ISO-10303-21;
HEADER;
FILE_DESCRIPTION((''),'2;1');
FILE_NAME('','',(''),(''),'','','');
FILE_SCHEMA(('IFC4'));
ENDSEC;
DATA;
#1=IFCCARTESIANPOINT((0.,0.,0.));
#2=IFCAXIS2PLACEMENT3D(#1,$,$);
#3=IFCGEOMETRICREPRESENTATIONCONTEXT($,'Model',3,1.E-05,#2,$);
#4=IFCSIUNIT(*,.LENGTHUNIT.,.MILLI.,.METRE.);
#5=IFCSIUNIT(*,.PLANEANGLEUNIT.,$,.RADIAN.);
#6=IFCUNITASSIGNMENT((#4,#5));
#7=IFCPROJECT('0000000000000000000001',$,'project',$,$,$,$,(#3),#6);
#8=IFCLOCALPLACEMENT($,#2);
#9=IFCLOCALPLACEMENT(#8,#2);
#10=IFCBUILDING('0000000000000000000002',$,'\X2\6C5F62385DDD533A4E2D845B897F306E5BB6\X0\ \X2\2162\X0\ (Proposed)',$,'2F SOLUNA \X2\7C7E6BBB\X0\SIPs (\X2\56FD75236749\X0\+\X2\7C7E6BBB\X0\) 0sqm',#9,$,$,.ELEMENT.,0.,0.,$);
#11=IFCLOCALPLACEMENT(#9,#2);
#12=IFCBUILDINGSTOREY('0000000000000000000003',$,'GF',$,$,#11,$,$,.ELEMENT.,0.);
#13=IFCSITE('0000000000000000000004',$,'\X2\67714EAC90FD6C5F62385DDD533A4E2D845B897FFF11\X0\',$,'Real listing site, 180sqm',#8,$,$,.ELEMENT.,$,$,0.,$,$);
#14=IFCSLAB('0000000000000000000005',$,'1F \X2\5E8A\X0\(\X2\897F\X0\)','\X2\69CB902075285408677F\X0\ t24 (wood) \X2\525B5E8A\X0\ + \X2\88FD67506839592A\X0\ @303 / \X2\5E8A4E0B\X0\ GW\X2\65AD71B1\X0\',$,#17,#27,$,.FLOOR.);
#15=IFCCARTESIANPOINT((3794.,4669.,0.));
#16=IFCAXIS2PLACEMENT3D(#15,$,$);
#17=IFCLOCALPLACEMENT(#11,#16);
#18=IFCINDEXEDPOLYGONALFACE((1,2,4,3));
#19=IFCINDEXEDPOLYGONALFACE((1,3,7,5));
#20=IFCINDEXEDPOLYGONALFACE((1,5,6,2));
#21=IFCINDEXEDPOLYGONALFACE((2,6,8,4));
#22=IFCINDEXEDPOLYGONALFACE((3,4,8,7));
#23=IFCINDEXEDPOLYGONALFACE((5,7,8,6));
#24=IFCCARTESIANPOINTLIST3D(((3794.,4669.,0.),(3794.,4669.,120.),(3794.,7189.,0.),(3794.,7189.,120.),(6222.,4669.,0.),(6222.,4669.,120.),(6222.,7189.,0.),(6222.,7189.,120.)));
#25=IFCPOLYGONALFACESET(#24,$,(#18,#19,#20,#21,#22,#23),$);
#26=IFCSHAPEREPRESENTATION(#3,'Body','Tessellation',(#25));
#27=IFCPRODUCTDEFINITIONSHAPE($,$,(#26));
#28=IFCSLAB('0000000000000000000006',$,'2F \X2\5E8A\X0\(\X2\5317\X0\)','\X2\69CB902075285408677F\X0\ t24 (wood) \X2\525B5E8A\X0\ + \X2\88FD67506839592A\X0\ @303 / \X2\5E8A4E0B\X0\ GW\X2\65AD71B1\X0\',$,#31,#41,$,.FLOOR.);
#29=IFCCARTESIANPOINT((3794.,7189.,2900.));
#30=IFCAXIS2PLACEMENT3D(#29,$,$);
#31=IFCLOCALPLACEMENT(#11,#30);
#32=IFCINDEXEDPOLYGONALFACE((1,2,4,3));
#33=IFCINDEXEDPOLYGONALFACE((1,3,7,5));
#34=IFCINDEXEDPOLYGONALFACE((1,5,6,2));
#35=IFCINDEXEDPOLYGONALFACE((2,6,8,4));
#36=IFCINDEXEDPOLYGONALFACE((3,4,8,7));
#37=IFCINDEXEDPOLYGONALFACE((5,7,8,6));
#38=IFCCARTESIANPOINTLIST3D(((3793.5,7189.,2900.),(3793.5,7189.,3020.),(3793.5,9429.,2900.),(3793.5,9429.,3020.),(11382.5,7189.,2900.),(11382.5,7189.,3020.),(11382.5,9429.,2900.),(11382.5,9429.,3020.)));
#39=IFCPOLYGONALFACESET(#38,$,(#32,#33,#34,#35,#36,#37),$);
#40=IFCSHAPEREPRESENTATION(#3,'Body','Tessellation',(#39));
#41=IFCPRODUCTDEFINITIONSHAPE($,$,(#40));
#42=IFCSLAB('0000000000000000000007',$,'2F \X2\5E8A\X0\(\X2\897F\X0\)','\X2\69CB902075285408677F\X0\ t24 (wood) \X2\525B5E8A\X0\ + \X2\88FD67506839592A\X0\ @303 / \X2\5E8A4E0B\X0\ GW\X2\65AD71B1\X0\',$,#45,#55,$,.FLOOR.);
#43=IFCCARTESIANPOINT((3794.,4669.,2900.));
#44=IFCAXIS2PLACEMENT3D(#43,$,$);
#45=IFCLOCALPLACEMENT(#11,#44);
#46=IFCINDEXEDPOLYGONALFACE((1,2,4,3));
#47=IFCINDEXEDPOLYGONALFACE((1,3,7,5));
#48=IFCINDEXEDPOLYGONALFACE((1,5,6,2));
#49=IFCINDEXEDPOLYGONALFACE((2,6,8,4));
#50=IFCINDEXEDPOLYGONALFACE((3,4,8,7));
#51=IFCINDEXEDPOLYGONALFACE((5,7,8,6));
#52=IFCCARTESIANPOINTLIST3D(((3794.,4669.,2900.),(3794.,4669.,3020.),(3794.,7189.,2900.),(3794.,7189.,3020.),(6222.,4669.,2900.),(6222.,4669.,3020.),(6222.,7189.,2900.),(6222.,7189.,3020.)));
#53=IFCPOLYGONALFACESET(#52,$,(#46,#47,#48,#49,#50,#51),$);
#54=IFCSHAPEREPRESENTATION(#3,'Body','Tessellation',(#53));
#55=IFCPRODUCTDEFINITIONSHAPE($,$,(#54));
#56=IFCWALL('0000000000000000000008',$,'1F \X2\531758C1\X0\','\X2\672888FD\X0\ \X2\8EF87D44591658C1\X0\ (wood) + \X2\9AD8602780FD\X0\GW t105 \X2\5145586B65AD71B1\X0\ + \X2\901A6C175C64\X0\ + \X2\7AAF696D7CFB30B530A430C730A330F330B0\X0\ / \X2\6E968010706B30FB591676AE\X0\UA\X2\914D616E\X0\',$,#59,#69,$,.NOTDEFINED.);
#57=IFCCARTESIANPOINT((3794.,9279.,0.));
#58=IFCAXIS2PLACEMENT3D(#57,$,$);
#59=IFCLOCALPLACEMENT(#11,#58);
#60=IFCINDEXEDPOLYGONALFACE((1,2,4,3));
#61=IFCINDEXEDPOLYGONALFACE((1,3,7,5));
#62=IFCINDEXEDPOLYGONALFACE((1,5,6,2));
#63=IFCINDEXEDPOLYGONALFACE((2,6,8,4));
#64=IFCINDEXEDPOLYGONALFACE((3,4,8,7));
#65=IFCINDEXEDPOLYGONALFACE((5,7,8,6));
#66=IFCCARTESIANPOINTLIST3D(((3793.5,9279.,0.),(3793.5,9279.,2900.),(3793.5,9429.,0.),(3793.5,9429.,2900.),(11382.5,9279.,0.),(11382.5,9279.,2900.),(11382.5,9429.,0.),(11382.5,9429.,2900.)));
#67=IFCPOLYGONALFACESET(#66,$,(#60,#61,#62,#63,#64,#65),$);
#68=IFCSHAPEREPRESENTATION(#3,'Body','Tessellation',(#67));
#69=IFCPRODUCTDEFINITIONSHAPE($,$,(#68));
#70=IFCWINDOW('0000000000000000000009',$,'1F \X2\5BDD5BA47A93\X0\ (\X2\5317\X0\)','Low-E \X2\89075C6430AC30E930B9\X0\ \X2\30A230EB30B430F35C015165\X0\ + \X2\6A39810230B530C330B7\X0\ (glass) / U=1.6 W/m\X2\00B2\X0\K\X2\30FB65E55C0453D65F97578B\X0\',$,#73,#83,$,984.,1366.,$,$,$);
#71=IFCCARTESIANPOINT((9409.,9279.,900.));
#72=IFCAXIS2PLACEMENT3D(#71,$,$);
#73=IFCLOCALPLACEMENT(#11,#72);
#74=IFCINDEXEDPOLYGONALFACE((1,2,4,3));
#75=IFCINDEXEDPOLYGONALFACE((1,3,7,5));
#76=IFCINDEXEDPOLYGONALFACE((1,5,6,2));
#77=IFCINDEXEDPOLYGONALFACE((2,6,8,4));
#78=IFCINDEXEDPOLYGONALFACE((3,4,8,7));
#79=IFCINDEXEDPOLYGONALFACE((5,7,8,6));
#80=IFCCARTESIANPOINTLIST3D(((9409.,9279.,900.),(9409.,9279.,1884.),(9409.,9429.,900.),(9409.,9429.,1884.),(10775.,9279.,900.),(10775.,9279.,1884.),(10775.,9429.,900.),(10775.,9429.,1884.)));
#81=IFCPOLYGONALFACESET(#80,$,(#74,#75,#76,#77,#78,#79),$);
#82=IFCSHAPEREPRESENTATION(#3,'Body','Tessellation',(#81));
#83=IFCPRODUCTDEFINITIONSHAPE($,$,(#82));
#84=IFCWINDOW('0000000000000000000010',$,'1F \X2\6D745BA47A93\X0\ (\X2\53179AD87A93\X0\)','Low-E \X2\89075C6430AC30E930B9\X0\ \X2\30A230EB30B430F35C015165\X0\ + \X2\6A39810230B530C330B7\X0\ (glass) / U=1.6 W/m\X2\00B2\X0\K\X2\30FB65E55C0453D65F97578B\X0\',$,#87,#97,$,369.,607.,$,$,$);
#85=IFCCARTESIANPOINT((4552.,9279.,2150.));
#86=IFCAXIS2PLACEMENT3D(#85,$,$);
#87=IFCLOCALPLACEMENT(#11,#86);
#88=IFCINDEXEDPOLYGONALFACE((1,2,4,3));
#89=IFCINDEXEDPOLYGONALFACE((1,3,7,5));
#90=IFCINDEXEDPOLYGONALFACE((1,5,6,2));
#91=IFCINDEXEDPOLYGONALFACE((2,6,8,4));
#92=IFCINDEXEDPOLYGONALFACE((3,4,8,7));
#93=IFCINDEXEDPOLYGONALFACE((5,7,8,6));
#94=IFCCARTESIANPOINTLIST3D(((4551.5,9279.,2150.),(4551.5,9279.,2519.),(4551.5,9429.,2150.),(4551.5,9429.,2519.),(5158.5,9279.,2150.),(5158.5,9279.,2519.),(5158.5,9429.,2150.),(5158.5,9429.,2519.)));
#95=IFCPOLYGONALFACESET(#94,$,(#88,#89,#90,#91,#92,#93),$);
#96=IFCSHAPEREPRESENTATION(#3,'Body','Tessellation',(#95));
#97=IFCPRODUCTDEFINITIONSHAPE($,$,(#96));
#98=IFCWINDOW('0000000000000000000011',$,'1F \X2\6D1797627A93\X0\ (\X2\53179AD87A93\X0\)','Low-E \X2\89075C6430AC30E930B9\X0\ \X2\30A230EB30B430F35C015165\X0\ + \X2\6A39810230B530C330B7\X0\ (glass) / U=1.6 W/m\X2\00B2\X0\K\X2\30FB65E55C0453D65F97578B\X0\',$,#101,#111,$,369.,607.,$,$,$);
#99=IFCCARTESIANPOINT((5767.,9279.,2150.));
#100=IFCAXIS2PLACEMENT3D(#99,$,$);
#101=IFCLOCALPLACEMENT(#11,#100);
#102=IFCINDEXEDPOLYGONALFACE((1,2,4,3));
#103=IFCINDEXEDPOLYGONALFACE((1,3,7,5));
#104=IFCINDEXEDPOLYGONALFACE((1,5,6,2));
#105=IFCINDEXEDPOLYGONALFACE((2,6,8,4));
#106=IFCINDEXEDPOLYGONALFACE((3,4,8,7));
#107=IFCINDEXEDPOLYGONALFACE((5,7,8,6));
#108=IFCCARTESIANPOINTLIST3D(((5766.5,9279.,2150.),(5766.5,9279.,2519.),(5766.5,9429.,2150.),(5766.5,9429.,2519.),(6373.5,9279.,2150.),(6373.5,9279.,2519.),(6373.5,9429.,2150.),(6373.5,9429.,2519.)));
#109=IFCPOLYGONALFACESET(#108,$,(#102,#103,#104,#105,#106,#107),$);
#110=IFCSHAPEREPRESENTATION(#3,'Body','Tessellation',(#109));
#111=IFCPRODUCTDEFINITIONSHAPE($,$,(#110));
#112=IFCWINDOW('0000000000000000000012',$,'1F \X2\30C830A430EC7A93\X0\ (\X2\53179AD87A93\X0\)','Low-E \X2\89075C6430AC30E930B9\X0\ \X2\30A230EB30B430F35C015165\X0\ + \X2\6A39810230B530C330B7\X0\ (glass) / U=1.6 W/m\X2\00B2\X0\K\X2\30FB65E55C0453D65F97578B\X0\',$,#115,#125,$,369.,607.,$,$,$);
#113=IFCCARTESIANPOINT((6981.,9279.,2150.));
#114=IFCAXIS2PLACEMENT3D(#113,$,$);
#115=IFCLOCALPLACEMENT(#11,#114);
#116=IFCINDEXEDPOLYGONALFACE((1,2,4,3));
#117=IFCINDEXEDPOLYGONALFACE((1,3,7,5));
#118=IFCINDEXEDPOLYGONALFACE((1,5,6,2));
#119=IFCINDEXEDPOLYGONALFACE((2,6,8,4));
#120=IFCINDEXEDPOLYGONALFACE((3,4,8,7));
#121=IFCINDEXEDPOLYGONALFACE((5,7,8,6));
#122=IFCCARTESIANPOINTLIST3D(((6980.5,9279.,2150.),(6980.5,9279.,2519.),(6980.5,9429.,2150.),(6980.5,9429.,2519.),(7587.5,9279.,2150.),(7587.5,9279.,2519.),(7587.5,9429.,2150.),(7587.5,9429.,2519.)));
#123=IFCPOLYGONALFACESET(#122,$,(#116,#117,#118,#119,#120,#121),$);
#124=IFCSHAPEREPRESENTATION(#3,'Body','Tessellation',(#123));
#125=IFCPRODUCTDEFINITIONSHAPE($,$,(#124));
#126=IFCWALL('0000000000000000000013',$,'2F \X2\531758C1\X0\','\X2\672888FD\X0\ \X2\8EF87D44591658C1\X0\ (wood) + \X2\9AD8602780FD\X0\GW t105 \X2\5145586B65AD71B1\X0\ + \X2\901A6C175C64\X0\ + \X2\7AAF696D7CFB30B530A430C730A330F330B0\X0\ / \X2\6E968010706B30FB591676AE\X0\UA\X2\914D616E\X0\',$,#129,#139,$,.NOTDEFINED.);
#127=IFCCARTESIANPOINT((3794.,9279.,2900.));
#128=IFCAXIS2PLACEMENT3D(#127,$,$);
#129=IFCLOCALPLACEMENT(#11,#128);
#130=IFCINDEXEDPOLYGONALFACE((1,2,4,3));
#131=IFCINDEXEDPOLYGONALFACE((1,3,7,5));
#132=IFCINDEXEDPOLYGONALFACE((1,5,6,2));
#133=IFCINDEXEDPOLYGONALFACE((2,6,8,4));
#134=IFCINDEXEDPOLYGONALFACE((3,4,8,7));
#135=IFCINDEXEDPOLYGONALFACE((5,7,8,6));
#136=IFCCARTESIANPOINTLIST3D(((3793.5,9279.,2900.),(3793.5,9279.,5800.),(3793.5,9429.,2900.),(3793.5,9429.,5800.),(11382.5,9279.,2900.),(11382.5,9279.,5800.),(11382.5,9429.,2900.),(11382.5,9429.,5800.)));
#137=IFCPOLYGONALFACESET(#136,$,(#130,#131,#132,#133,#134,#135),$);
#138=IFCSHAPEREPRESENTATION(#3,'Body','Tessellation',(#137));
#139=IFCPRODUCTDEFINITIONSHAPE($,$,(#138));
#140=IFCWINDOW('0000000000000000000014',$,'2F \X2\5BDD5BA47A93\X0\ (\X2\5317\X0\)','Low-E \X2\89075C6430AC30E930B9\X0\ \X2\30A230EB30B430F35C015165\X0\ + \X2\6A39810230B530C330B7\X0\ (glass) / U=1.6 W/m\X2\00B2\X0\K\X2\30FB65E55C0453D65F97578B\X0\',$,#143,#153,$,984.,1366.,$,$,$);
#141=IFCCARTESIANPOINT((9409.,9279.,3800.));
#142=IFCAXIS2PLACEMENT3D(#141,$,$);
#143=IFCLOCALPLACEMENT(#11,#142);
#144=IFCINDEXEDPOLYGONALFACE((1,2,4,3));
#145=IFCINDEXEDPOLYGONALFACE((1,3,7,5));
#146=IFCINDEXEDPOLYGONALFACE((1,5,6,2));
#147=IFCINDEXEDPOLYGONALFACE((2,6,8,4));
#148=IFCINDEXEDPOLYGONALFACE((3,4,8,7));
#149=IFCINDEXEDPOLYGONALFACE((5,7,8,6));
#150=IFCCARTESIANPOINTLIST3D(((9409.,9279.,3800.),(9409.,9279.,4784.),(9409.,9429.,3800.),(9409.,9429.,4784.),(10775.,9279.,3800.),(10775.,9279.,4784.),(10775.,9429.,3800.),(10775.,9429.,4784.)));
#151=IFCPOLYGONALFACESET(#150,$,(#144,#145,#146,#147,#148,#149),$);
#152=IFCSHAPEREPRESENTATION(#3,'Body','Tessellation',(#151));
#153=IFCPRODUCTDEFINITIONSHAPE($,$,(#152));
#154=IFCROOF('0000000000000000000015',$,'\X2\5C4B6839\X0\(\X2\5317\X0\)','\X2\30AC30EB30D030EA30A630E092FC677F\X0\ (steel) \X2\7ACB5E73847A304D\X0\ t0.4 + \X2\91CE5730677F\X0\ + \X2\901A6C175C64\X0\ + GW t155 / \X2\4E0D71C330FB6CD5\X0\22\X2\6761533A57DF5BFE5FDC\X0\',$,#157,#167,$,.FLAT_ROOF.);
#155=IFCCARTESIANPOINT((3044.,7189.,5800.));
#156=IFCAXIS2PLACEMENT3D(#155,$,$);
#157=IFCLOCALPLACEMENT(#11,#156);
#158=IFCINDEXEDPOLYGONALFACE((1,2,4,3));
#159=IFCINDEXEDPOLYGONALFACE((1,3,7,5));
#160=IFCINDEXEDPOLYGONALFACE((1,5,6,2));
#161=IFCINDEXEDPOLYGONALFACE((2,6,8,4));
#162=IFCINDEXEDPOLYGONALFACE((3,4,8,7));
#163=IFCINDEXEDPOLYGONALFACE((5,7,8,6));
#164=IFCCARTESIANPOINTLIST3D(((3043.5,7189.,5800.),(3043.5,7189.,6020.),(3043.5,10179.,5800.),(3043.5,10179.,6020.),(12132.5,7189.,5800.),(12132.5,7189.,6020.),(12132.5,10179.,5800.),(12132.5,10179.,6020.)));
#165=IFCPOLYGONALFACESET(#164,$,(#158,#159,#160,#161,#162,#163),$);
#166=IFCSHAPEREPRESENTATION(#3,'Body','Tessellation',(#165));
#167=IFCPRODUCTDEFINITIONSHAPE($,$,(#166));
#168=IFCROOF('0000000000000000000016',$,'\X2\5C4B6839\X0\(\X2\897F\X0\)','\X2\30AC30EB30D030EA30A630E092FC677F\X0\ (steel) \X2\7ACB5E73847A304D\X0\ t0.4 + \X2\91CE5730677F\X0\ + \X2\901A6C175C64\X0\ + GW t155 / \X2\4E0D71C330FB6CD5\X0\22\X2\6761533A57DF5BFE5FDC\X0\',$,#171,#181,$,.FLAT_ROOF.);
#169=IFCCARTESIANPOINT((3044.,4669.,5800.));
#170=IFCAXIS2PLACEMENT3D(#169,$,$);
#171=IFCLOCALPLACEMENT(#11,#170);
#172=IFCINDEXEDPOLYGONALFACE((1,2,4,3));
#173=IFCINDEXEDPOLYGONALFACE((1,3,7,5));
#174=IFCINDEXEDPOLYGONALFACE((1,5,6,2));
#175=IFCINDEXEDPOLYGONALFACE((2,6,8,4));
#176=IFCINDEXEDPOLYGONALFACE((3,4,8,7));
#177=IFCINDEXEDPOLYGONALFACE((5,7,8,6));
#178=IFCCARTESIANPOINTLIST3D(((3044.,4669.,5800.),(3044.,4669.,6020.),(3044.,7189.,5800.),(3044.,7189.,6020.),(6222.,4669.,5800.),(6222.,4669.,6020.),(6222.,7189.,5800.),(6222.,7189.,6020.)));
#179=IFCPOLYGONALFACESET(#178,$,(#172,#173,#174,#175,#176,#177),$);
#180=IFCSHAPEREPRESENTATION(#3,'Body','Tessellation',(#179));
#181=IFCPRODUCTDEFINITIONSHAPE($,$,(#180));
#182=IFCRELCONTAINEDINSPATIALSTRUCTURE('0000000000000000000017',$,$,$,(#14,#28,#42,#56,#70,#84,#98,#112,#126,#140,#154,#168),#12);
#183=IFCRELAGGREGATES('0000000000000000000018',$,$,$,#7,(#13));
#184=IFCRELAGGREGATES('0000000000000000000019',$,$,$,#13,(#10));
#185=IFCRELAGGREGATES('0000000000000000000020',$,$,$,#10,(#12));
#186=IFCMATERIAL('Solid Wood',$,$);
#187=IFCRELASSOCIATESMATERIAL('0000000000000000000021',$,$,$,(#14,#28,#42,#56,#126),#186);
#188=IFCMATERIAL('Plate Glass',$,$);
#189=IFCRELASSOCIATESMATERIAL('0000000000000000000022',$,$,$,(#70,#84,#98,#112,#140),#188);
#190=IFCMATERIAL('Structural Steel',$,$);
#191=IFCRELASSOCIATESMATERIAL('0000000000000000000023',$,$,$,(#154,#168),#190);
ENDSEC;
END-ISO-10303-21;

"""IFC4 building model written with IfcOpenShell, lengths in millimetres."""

from ifc_helpers import new_model, si_unit, frame, frame_2d, origin, place, context, project, spatial, rectangle, extrude, material, element, fill, save


model = new_model("IFC4")

# Units and contexts
model_context = context("Model", 3, precision=1e-05, world=origin())
ifc_project = project(units=[si_unit("LENGTHUNIT", "METRE", prefix="MILLI"), si_unit("PLANEANGLEUNIT", "RADIAN")], contexts=[model_context])

# Site, building, storey
site_placement = place(None, origin())
site = spatial("IfcSite", under=ifc_project, at=site_placement, Name="東京都江戸川区中葛西１", ObjectType="Real listing site, 180sqm", CompositionType="ELEMENT", RefElevation=0.0)
building_placement = place(site_placement, origin())
building = spatial("IfcBuilding", under=site, at=building_placement, Name="江戸川区中葛西の家 Ⅲ (Proposed)", ObjectType="2F SOLUNA 籾殻SIPs (国産杉+籾殻) 0sqm", CompositionType="ELEMENT", ElevationOfRefHeight=0.0, ElevationOfTerrain=0.0)
storey_placement = place(building_placement, origin())
storey = spatial("IfcBuildingStorey", under=building, at=storey_placement, Name="GF", CompositionType="ELEMENT", Elevation=0.0)

# Slabs
ifc_material_1 = material(Name="Solid Wood")
slab_1_placement = place(storey_placement, frame((3794.0, 4669.0, 0.0)))
element("IfcSlab", 1, at=slab_1_placement, inside=storey, material=ifc_material_1, Name="1F 床(西)", Description="構造用合板 t24 (wood) 剛床 + 製材根太 @303 / 床下 GW断熱", PredefinedType="FLOOR", context=model_context, shape_type="SweptSolid", body=[
    extrude(rectangle(XDim=2428.0, YDim=2520.0, at=frame_2d((1214.0, 1260.0))), frame((3794.0, 4669.0, 0.0)), (0.0, 0.0, 1.0), 120.0),
])
slab_2_placement = place(storey_placement, frame((3794.0, 7189.0, 2900.0)))
element("IfcSlab", 2, at=slab_2_placement, inside=storey, material=ifc_material_1, Name="2F 床(北)", Description="構造用合板 t24 (wood) 剛床 + 製材根太 @303 / 床下 GW断熱", PredefinedType="FLOOR", context=model_context, shape_type="SweptSolid", body=[
    extrude(rectangle(XDim=7589.0, YDim=2240.0, at=frame_2d((3794.0, 1120.0))), frame((3794.0, 7189.0, 2900.0)), (0.0, 0.0, 1.0), 120.0),
])
slab_3_placement = place(storey_placement, frame((3794.0, 4669.0, 2900.0)))
element("IfcSlab", 3, at=slab_3_placement, inside=storey, material=ifc_material_1, Name="2F 床(西)", Description="構造用合板 t24 (wood) 剛床 + 製材根太 @303 / 床下 GW断熱", PredefinedType="FLOOR", context=model_context, shape_type="SweptSolid", body=[
    extrude(rectangle(XDim=2428.0, YDim=2520.0, at=frame_2d((1214.0, 1260.0))), frame((3794.0, 4669.0, 2900.0)), (0.0, 0.0, 1.0), 120.0),
])

# Wall, openings, windows
wall_1_placement = place(storey_placement, frame((3794.0, 9279.0, 0.0)))
wall_1 = element("IfcWall", 4, at=wall_1_placement, inside=storey, material=ifc_material_1, Name="1F 北壁", Description="木製 軸組外壁 (wood) + 高性能GW t105 充填断熱 + 通気層 + 窯業系サイディング / 準耐火・外皮UA配慮", PredefinedType="NOTDEFINED", context=model_context, shape_type="SweptSolid", body=[
    extrude(rectangle(XDim=7589.0, YDim=150.0, at=frame_2d((3794.0, 75.0))), frame((3794.0, 9279.0, 0.0)), (0.0, 0.0, 1.0), 2900.0),
])
opening_1_placement = place(storey_placement, frame((9409.0, 9279.0, 900.0)))
opening_1 = element("IfcOpeningElement", 5, at=opening_1_placement, cuts=wall_1, PredefinedType="NOTDEFINED", context=model_context, shape_type="SweptSolid", body=[
    extrude(rectangle(XDim=1366.0, YDim=150.0, at=frame_2d((683.0, 75.0))), frame((9409.0, 9279.0, 900.0)), (0.0, 0.0, 1.0), 984.0),
])
opening_2_placement = place(storey_placement, frame((4552.0, 9279.0, 2150.0)))
opening_2 = element("IfcOpeningElement", 6, at=opening_2_placement, cuts=wall_1, PredefinedType="NOTDEFINED", context=model_context, shape_type="SweptSolid", body=[
    extrude(rectangle(XDim=607.0, YDim=150.0, at=frame_2d((303.0, 75.0))), frame((4552.0, 9279.0, 2150.0)), (0.0, 0.0, 1.0), 369.0),
])
opening_3_placement = place(storey_placement, frame((5767.0, 9279.0, 2150.0)))
opening_3 = element("IfcOpeningElement", 7, at=opening_3_placement, cuts=wall_1, PredefinedType="NOTDEFINED", context=model_context, shape_type="SweptSolid", body=[
    extrude(rectangle(XDim=607.0, YDim=150.0, at=frame_2d((303.0, 75.0))), frame((5767.0, 9279.0, 2150.0)), (0.0, 0.0, 1.0), 369.0),
])
opening_4_placement = place(storey_placement, frame((6981.0, 9279.0, 2150.0)))
opening_4 = element("IfcOpeningElement", 8, at=opening_4_placement, cuts=wall_1, PredefinedType="NOTDEFINED", context=model_context, shape_type="SweptSolid", body=[
    extrude(rectangle(XDim=607.0, YDim=150.0, at=frame_2d((303.0, 75.0))), frame((6981.0, 9279.0, 2150.0)), (0.0, 0.0, 1.0), 369.0),
])
ifc_material_2 = material(Name="Plate Glass")
window_1_placement = place(storey_placement, frame((9409.0, 9279.0, 900.0)))
window_1 = element("IfcWindow", 9, at=window_1_placement, inside=storey, material=ifc_material_2, Name="1F 寝室窓 (北)", Description="Low-E 複層ガラス アルゴン封入 + 樹脂サッシ (glass) / U=1.6 W/m²K・日射取得型", OverallHeight=984.0, OverallWidth=1366.0, context=model_context, shape_type="SweptSolid", body=[
    extrude(rectangle(XDim=1366.0, YDim=150.0, at=frame_2d((683.0, 75.0))), frame((9409.0, 9279.0, 900.0)), (0.0, 0.0, 1.0), 984.0),
])
fill(opening_1, window_1)
window_2_placement = place(storey_placement, frame((4552.0, 9279.0, 2150.0)))
window_2 = element("IfcWindow", 10, at=window_2_placement, inside=storey, material=ifc_material_2, Name="1F 浴室窓 (北高窓)", Description="Low-E 複層ガラス アルゴン封入 + 樹脂サッシ (glass) / U=1.6 W/m²K・日射取得型", OverallHeight=369.0, OverallWidth=607.0, context=model_context, shape_type="SweptSolid", body=[
    extrude(rectangle(XDim=607.0, YDim=150.0, at=frame_2d((303.0, 75.0))), frame((4552.0, 9279.0, 2150.0)), (0.0, 0.0, 1.0), 369.0),
])
fill(opening_2, window_2)
window_3_placement = place(storey_placement, frame((5767.0, 9279.0, 2150.0)))
window_3 = element("IfcWindow", 11, at=window_3_placement, inside=storey, material=ifc_material_2, Name="1F 洗面窓 (北高窓)", Description="Low-E 複層ガラス アルゴン封入 + 樹脂サッシ (glass) / U=1.6 W/m²K・日射取得型", OverallHeight=369.0, OverallWidth=607.0, context=model_context, shape_type="SweptSolid", body=[
    extrude(rectangle(XDim=607.0, YDim=150.0, at=frame_2d((303.0, 75.0))), frame((5767.0, 9279.0, 2150.0)), (0.0, 0.0, 1.0), 369.0),
])
fill(opening_3, window_3)
window_4_placement = place(storey_placement, frame((6981.0, 9279.0, 2150.0)))
window_4 = element("IfcWindow", 12, at=window_4_placement, inside=storey, material=ifc_material_2, Name="1F トイレ窓 (北高窓)", Description="Low-E 複層ガラス アルゴン封入 + 樹脂サッシ (glass) / U=1.6 W/m²K・日射取得型", OverallHeight=369.0, OverallWidth=607.0, context=model_context, shape_type="SweptSolid", body=[
    extrude(rectangle(XDim=607.0, YDim=150.0, at=frame_2d((303.0, 75.0))), frame((6981.0, 9279.0, 2150.0)), (0.0, 0.0, 1.0), 369.0),
])
fill(opening_4, window_4)

# Wall, opening, window
wall_2_placement = place(storey_placement, frame((3794.0, 9279.0, 2900.0)))
wall_2 = element("IfcWall", 13, at=wall_2_placement, inside=storey, material=ifc_material_1, Name="2F 北壁", Description="木製 軸組外壁 (wood) + 高性能GW t105 充填断熱 + 通気層 + 窯業系サイディング / 準耐火・外皮UA配慮", PredefinedType="NOTDEFINED", context=model_context, shape_type="SweptSolid", body=[
    extrude(rectangle(XDim=7589.0, YDim=150.0, at=frame_2d((3794.0, 75.0))), frame((3794.0, 9279.0, 2900.0)), (0.0, 0.0, 1.0), 2900.0),
])
opening_5_placement = place(storey_placement, frame((9409.0, 9279.0, 3800.0)))
opening_5 = element("IfcOpeningElement", 14, at=opening_5_placement, cuts=wall_2, PredefinedType="NOTDEFINED", context=model_context, shape_type="SweptSolid", body=[
    extrude(rectangle(XDim=1366.0, YDim=150.0, at=frame_2d((683.0, 75.0))), frame((9409.0, 9279.0, 3800.0)), (0.0, 0.0, 1.0), 984.0),
])
window_5_placement = place(storey_placement, frame((9409.0, 9279.0, 3800.0)))
window_5 = element("IfcWindow", 15, at=window_5_placement, inside=storey, material=ifc_material_2, Name="2F 寝室窓 (北)", Description="Low-E 複層ガラス アルゴン封入 + 樹脂サッシ (glass) / U=1.6 W/m²K・日射取得型", OverallHeight=984.0, OverallWidth=1366.0, context=model_context, shape_type="SweptSolid", body=[
    extrude(rectangle(XDim=1366.0, YDim=150.0, at=frame_2d((683.0, 75.0))), frame((9409.0, 9279.0, 3800.0)), (0.0, 0.0, 1.0), 984.0),
])
fill(opening_5, window_5)

# Roofs
ifc_material_3 = material(Name="Structural Steel")
for number, where, name in (
    (16, (3044.0, 7189.0, 5800.0), "屋根(北)"),
):
    element("IfcRoof", number, at=place(storey_placement, frame(where)), inside=storey, material=ifc_material_3, Name=name, Description="ガルバリウム鋼板 (steel) 立平葺き t0.4 + 野地板 + 通気層 + GW t155 / 不燃・法22条区域対応", PredefinedType="FLAT_ROOF", context=model_context, shape_type="SweptSolid", body=[
        extrude(rectangle(XDim=9089.0, YDim=2990.0, at=frame_2d((4544.0, 1495.0))), frame((3044.0, 7189.0, 5800.0)), (0.0, 0.0, 1.0), 220.0),
    ])
roof_placement = place(storey_placement, frame((3044.0, 4669.0, 5800.0)))
element("IfcRoof", 17, at=roof_placement, inside=storey, material=ifc_material_3, Name="屋根(西)", Description="ガルバリウム鋼板 (steel) 立平葺き t0.4 + 野地板 + 通気層 + GW t155 / 不燃・法22条区域対応", PredefinedType="FLAT_ROOF", context=model_context, shape_type="SweptSolid", body=[
    extrude(rectangle(XDim=3178.0, YDim=2520.0, at=frame_2d((1589.0, 1260.0))), frame((3044.0, 4669.0, 5800.0)), (0.0, 0.0, 1.0), 220.0),
])

save(model, "model.ifc")
